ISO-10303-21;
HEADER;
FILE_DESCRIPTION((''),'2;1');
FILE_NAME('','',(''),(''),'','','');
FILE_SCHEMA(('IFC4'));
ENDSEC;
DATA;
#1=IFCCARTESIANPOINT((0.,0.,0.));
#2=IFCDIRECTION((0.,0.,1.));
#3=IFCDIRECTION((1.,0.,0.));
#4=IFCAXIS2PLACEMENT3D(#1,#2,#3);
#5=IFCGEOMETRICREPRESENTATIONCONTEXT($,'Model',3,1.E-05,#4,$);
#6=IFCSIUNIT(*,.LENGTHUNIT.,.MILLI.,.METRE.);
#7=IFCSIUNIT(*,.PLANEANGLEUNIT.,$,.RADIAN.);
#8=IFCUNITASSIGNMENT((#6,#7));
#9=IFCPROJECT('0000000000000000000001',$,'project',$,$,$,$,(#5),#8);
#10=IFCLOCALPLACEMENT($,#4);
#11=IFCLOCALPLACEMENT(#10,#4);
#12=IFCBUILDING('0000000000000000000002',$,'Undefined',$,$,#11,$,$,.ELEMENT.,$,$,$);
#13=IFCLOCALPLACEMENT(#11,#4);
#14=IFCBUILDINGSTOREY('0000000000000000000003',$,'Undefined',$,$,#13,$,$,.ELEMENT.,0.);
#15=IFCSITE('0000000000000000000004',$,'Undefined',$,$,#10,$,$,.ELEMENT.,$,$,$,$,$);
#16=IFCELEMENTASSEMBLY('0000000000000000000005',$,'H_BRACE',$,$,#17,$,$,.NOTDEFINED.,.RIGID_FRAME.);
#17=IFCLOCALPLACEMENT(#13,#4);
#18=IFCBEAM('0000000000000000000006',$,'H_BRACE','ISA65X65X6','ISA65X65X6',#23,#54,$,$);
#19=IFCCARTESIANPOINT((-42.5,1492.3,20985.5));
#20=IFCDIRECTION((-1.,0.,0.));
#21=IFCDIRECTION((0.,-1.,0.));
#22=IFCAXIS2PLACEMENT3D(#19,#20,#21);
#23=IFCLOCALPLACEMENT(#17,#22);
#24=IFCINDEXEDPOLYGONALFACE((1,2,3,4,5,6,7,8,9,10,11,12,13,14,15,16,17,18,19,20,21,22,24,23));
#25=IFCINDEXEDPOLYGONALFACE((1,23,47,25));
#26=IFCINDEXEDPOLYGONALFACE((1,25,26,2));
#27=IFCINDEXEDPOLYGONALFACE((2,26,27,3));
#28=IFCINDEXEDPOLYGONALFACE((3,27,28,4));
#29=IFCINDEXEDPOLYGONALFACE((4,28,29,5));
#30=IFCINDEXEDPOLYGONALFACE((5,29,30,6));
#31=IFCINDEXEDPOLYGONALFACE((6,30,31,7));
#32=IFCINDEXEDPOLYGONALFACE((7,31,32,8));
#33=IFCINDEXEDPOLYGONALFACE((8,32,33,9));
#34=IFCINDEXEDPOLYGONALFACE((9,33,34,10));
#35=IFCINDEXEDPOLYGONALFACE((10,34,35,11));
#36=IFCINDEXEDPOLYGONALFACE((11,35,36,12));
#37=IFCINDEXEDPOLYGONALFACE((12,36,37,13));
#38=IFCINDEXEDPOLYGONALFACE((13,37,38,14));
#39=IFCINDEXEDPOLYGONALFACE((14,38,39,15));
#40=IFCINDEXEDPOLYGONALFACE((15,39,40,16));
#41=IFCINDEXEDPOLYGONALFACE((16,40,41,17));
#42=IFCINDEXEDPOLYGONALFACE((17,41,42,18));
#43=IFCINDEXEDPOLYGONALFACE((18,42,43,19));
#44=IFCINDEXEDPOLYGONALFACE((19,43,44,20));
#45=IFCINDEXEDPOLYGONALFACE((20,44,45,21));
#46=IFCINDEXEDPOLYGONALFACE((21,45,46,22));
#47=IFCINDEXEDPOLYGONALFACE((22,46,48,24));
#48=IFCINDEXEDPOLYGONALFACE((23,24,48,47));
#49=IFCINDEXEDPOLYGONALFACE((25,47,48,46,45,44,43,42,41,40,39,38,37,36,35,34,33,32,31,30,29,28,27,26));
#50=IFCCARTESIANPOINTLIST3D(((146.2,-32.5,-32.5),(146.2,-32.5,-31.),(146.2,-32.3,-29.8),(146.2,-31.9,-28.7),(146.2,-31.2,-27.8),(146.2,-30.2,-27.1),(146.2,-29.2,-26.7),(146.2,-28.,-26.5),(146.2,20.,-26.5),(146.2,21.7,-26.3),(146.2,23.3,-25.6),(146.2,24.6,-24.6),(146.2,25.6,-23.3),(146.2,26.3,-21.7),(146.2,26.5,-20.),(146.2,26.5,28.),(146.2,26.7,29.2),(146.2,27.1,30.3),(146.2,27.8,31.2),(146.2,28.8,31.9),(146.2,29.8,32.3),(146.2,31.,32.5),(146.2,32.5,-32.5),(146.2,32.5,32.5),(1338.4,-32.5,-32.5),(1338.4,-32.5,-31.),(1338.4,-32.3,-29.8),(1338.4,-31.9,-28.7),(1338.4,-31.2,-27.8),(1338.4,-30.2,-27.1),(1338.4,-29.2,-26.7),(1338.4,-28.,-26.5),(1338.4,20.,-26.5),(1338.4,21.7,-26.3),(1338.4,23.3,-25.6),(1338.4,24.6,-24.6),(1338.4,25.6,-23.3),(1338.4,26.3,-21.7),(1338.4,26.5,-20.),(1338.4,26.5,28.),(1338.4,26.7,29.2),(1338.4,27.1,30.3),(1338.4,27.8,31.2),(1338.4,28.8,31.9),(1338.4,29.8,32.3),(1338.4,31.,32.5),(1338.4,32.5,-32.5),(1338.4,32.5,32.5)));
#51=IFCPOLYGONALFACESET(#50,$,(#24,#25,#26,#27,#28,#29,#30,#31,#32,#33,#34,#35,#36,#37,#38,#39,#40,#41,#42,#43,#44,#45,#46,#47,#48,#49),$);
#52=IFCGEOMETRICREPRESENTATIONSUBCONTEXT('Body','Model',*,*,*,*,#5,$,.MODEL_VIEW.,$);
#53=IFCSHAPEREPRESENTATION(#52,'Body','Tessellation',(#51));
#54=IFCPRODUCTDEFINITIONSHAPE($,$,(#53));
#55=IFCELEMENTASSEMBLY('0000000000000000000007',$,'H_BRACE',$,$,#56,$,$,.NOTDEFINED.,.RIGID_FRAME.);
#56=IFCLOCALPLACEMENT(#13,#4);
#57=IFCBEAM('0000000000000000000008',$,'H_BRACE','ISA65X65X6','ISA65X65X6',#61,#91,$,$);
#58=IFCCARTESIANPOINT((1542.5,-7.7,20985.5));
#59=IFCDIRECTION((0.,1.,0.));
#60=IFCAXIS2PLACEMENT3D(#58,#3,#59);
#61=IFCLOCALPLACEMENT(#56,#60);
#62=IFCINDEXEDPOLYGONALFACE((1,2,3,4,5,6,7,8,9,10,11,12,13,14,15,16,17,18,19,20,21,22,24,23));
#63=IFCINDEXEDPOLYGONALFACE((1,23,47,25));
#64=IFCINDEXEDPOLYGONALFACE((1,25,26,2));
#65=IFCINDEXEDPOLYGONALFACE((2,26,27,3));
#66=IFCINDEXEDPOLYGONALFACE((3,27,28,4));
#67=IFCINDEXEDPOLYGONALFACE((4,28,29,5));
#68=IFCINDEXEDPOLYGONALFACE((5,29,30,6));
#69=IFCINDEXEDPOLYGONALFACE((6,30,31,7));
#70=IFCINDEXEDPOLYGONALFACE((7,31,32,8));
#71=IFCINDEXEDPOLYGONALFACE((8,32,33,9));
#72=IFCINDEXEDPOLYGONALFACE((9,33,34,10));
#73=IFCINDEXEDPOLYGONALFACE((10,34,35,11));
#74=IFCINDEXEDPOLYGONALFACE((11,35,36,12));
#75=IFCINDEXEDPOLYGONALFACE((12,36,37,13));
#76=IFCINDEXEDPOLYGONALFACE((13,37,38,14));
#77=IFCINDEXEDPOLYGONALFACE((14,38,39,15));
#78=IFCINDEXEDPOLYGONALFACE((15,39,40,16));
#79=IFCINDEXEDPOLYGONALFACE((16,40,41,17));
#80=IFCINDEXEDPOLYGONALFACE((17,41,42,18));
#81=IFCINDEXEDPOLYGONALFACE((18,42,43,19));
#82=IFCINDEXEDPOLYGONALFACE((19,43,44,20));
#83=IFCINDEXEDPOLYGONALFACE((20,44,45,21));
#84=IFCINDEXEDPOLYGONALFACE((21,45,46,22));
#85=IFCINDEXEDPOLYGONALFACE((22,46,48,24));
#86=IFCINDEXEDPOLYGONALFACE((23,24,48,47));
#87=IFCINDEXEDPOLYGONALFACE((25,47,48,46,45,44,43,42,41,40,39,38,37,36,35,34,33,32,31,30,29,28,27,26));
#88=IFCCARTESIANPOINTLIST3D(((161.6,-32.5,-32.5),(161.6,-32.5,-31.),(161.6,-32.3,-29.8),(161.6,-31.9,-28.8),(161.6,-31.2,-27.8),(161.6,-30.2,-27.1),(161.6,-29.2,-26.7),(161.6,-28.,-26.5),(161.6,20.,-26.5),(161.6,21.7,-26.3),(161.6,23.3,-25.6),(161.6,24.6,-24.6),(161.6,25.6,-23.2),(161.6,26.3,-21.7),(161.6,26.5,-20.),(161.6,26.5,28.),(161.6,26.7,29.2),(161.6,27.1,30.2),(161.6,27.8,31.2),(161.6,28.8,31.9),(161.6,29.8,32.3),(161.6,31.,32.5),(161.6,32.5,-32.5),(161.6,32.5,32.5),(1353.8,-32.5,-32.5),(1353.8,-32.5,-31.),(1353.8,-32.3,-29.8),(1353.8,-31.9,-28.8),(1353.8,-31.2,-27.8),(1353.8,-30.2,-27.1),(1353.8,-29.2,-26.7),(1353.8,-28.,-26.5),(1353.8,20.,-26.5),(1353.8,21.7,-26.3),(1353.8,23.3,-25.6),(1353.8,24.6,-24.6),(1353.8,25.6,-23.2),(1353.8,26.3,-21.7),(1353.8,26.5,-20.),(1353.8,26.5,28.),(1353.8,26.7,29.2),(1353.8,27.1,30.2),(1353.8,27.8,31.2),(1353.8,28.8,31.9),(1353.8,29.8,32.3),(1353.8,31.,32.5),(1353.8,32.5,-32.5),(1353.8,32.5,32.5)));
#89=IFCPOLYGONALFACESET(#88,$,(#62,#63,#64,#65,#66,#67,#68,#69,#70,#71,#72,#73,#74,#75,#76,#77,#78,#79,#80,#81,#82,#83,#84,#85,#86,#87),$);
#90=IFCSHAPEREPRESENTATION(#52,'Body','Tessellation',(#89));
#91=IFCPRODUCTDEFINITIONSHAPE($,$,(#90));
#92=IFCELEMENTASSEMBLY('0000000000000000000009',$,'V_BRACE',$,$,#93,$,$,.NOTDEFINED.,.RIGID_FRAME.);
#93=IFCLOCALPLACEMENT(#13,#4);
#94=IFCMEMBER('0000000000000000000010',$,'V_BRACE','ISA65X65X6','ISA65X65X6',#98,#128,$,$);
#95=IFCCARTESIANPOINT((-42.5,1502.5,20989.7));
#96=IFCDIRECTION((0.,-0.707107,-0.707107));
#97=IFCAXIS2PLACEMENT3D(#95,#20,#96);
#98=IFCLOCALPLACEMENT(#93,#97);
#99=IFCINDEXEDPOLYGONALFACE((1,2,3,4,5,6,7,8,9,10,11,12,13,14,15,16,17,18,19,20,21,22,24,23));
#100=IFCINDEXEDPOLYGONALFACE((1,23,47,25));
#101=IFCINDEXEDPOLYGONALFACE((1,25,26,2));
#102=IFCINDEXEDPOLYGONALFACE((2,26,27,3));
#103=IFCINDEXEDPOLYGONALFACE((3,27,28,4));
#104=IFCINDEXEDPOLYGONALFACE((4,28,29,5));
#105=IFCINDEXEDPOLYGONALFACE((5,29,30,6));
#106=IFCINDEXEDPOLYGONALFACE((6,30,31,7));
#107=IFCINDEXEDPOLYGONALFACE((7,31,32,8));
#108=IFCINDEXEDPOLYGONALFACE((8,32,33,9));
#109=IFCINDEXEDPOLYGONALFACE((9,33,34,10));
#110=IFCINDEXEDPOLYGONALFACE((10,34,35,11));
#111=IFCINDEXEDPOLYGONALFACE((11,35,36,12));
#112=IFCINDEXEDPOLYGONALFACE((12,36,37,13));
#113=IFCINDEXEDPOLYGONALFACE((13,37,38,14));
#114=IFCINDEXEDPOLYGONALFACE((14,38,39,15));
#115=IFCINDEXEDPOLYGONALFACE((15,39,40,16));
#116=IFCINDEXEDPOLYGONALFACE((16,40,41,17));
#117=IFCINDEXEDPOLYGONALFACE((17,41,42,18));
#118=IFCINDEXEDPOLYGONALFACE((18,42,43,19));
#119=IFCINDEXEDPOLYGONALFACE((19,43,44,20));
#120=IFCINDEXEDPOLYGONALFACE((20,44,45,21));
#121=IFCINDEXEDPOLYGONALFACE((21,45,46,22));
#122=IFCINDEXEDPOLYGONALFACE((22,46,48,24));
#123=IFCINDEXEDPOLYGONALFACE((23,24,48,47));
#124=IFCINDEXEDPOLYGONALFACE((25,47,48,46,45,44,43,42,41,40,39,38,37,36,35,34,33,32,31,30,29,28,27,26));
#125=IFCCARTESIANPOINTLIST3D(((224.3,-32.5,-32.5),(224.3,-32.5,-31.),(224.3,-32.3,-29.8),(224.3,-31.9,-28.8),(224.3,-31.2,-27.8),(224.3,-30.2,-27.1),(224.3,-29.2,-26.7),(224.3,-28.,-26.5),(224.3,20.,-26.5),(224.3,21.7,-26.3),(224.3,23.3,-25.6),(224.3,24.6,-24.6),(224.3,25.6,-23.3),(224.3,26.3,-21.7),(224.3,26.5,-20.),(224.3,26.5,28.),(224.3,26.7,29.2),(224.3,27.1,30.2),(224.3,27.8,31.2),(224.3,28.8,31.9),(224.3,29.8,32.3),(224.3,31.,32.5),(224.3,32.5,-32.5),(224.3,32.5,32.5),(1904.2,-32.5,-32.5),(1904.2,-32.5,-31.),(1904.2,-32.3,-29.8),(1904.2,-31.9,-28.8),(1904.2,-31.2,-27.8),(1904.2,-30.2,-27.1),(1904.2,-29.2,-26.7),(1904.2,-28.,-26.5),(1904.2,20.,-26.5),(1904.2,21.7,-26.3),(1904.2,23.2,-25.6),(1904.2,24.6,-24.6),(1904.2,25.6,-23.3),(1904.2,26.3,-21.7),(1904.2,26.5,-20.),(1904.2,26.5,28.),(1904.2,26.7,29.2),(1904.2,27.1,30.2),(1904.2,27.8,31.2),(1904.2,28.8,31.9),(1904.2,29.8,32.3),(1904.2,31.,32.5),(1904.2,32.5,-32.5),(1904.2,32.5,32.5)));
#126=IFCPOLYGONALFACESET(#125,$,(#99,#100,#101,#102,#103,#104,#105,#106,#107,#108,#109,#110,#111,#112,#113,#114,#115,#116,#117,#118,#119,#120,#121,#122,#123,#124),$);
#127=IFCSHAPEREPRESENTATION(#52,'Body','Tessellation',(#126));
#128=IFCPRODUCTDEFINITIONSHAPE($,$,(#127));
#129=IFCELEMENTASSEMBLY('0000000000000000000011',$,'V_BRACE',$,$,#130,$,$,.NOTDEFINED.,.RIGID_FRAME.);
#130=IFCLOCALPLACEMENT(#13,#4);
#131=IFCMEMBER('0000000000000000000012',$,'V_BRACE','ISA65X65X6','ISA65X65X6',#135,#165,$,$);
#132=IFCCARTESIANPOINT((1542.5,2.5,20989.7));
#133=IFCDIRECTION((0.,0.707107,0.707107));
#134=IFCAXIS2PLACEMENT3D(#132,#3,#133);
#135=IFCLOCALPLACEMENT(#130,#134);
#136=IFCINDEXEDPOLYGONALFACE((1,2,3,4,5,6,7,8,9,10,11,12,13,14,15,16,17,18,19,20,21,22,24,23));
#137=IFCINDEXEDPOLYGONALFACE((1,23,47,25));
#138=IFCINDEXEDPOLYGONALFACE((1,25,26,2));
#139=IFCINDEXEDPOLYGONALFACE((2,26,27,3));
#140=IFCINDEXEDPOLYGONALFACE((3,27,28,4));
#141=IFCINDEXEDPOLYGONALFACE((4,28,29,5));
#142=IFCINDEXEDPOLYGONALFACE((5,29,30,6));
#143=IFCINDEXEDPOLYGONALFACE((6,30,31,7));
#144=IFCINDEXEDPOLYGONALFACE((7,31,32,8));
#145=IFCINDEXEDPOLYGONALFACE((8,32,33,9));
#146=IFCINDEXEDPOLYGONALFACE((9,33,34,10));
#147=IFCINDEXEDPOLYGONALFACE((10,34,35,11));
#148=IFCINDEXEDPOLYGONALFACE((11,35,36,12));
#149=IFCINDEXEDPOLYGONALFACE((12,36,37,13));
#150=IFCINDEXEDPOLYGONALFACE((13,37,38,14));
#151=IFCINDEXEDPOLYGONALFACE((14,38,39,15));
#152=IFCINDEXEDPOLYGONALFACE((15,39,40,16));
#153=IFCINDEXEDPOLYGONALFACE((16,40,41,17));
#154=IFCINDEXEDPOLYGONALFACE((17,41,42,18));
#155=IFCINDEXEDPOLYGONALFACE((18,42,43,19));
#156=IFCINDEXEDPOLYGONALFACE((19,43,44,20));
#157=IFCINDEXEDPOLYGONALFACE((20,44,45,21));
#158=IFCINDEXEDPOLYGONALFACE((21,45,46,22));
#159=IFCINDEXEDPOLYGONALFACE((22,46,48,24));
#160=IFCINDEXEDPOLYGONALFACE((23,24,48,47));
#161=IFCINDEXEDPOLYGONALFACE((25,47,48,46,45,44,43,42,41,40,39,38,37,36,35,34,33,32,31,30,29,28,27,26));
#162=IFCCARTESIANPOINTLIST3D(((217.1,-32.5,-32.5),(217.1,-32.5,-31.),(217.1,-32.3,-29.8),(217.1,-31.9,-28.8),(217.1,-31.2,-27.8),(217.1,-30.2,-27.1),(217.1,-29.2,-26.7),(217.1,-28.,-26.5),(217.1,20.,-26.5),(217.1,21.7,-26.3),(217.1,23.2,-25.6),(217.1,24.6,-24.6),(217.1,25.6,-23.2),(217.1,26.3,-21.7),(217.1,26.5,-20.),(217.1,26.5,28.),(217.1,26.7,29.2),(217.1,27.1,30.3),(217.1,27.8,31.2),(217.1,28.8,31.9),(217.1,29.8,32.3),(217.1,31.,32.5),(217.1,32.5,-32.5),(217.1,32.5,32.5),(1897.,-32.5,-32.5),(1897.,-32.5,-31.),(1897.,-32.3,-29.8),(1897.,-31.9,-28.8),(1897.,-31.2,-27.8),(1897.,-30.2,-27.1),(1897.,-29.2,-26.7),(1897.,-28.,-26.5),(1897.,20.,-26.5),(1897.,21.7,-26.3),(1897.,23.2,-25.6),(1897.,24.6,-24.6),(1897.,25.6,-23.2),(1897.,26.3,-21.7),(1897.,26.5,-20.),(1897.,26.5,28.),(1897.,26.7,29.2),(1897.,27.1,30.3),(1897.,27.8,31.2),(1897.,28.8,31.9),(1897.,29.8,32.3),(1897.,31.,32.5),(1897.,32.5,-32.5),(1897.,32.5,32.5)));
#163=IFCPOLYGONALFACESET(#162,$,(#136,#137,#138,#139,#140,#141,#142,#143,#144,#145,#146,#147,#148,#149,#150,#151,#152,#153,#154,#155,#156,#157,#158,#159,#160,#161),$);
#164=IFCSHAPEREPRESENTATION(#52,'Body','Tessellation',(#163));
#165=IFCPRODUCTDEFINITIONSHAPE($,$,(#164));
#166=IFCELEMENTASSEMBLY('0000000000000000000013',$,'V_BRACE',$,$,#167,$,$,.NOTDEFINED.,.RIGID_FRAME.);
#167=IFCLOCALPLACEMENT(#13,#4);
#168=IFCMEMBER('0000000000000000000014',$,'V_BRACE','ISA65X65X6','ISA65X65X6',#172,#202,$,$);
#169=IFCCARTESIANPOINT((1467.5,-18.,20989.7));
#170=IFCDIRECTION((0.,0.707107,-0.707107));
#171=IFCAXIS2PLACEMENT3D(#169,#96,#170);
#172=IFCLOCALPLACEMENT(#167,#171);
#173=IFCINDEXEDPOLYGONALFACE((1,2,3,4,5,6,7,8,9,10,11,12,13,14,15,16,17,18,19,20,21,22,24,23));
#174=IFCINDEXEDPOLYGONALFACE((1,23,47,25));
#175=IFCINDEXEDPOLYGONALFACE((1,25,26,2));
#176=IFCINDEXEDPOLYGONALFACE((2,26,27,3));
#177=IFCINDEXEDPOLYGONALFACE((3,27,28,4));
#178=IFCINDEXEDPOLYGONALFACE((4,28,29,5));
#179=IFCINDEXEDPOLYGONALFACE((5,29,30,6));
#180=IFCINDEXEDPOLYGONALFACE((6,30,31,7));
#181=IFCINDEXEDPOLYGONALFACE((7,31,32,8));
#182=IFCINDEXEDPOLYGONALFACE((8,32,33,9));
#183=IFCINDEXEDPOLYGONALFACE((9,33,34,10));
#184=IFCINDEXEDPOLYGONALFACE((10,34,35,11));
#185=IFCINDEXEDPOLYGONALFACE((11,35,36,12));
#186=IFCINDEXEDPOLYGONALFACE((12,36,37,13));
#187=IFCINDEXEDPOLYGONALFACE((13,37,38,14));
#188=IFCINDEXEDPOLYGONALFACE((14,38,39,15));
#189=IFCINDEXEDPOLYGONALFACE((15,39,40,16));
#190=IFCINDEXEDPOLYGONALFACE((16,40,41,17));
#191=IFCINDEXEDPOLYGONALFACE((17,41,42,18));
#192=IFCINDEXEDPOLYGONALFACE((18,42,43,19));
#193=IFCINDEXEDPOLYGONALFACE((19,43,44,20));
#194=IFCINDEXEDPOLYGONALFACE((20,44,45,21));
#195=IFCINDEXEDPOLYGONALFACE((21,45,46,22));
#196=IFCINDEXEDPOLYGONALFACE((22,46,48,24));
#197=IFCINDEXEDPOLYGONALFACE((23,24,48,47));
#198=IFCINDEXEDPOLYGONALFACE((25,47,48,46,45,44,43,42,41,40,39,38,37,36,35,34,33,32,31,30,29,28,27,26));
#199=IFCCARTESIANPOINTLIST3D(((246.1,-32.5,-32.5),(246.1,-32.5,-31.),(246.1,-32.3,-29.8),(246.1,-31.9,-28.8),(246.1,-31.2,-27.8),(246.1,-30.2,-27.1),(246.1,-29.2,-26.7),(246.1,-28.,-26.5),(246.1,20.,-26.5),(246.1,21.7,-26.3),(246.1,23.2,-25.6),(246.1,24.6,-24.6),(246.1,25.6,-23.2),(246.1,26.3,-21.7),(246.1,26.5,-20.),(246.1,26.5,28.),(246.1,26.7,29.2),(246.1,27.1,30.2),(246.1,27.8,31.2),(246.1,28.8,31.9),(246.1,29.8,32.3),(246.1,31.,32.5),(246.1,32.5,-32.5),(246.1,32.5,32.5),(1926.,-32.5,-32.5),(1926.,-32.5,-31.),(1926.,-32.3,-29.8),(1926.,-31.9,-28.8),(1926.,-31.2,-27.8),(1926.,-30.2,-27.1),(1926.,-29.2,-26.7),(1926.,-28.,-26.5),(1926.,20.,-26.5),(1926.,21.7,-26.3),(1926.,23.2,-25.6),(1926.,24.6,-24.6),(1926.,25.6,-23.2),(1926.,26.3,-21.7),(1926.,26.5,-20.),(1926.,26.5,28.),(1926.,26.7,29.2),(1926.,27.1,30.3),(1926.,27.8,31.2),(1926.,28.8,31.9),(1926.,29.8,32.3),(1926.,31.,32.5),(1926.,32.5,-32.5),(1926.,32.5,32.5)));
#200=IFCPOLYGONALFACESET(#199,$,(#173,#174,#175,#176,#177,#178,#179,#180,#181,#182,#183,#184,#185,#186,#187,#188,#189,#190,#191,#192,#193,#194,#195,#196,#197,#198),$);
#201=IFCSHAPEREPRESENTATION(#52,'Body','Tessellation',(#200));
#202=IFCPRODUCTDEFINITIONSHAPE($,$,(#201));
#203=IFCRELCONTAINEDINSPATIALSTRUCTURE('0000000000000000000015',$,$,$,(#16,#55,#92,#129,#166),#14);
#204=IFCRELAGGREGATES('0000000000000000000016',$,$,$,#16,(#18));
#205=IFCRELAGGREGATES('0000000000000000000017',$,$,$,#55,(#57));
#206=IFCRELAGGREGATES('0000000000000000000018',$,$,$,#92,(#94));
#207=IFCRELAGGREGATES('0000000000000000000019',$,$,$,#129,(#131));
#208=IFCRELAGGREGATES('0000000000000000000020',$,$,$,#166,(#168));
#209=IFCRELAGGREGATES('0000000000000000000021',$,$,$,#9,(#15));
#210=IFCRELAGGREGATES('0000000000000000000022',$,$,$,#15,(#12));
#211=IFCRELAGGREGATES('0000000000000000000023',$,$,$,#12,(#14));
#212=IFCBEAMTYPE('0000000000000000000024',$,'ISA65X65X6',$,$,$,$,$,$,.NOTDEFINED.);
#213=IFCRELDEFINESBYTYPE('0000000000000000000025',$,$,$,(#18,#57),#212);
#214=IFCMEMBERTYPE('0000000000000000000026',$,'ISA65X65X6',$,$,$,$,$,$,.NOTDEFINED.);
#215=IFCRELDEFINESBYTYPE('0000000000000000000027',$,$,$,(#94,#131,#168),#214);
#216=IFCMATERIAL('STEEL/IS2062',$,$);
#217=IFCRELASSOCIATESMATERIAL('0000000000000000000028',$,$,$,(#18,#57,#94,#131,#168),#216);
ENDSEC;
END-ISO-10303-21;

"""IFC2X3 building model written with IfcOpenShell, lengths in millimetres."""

from ifc_helpers import new_model, si_unit, frame, origin_with_axes, origin_2d_with_axis, place, context, subcontext, project, spatial, l_section, extrude, clip, halfspace, material, type_object, element, aggregate, save


model = new_model("IFC2X3")

# Units and contexts
model_context = context("Model", 3, precision=1e-05, world=origin_with_axes())
body_context = subcontext(model_context, "Body", "Model", "MODEL_VIEW")
ifc_project = project(units=[si_unit("LENGTHUNIT", "METRE", prefix="MILLI"), si_unit("PLANEANGLEUNIT", "RADIAN")], contexts=[model_context])

# Site, building, storey
site_placement = place(None, origin_with_axes())
site = spatial("IfcSite", under=ifc_project, at=site_placement, Name="Undefined", CompositionType="ELEMENT")
building_placement = place(site_placement, origin_with_axes())
building = spatial("IfcBuilding", under=site, at=building_placement, Name="Undefined", CompositionType="ELEMENT")
storey_placement = place(building_placement, origin_with_axes())
storey = spatial("IfcBuildingStorey", under=building, at=storey_placement, Name="Undefined", CompositionType="ELEMENT", Elevation=0.0)

# Shared definitions
ifc_material = material(Name="STEEL/IS2062")

# Element assemblies, beams
assembly_1_placement = place(storey_placement, origin_with_axes())
assembly_1 = element("IfcElementAssembly", 1, at=assembly_1_placement, inside=storey, Name="H_BRACE", AssemblyPlace="NOTDEFINED", PredefinedType="RIGID_FRAME")
beam_type_1 = type_object("IfcBeamType", Name="ISA65X65X6", PredefinedType="NOTDEFINED")
beam_1_placement = place(assembly_1_placement, frame((-42.5, 1492.3, 20985.5), z_axis=(-1.0, 0.0, 0.0), x_axis=(0.0, -1.0, 0.0)))
beam_1 = element("IfcBeam", 2, at=beam_1_placement, type_object=beam_type_1, material=ifc_material, Name="H_BRACE", Description="ISA65X65X6", ObjectType="ISA65X65X6", context=body_context, shape_type="Clipping", body=[
    clip(clip(extrude(l_section(Depth=65.0, Width=65.0, Thickness=6.0, FilletRadius=6.5, EdgeRadius=4.5, at=origin_2d_with_axis()), frame((1500.0, 0.0, 0.0), z_axis=(-1.0, 0.0, 0.0), x_axis=(0.0, -1.0, 0.0)), (0.0, 0.0, 1.0), 1500.0), halfspace(frame((1338.4, 0.0, -32.5), z_axis=(-1.0, 0.0, 0.0), x_axis=(0.0, -1.0, 0.0)), True)), halfspace(frame((146.2, 0.0, -32.5), z_axis=(1.0, 0.0, 0.0), x_axis=(0.0, 1.0, 0.0)), True)),
])
aggregate(assembly_1, [beam_1])
assembly_2_placement = place(storey_placement, origin_with_axes())
assembly_2 = element("IfcElementAssembly", 3, at=assembly_2_placement, inside=storey, Name="H_BRACE", AssemblyPlace="NOTDEFINED", PredefinedType="RIGID_FRAME")
beam_2_placement = place(assembly_2_placement, frame((1542.5, -7.7, 20985.5), z_axis=(1.0, 0.0, 0.0), x_axis=(0.0, 1.0, 0.0)))
beam_2 = element("IfcBeam", 4, at=beam_2_placement, type_object=beam_type_1, material=ifc_material, Name="H_BRACE", Description="ISA65X65X6", ObjectType="ISA65X65X6", context=body_context, shape_type="Clipping", body=[
    clip(clip(extrude(l_section(Depth=65.0, Width=65.0, Thickness=6.0, FilletRadius=6.5, EdgeRadius=4.5, at=origin_2d_with_axis()), frame((1500.0, 0.0, 0.0), z_axis=(-1.0, 0.0, 0.0), x_axis=(0.0, -1.0, 0.0)), (0.0, 0.0, 1.0), 1500.0), halfspace(frame((1353.8, 0.0, -42.5), z_axis=(-1.0, 0.0, 0.0), x_axis=(0.0, 1.0, 0.0)), True)), halfspace(frame((161.6, 0.0, -42.5), z_axis=(1.0, 0.0, 0.0), x_axis=(0.0, -1.0, 0.0)), True)),
])
aggregate(assembly_2, [beam_2])

# Element assemblies, members
assembly_3_placement = place(storey_placement, origin_with_axes())
assembly_3 = element("IfcElementAssembly", 5, at=assembly_3_placement, inside=storey, Name="V_BRACE", AssemblyPlace="NOTDEFINED", PredefinedType="RIGID_FRAME")
member_type = type_object("IfcMemberType", Name="ISA65X65X6", PredefinedType="NOTDEFINED")
member_1_placement = place(assembly_3_placement, frame((-42.5, 1502.5, 20989.7), z_axis=(-1.0, 0.0, 0.0), x_axis=(0.0, -0.707107, -0.707107)))
member_1 = element("IfcMember", 6, at=member_1_placement, type_object=member_type, material=ifc_material, Name="V_BRACE", Description="ISA65X65X6", ObjectType="ISA65X65X6", context=body_context, shape_type="Clipping", body=[
    clip(clip(extrude(l_section(Depth=65.0, Width=65.0, Thickness=6.0, FilletRadius=6.5, EdgeRadius=4.5, at=origin_2d_with_axis()), frame((2121.3, 0.0, 0.0), z_axis=(-1.0, 0.0, 0.0), x_axis=(0.0, -1.0, 0.0)), (0.0, 0.0, 1.0), 2121.3), halfspace(frame((1904.2, 0.0, -32.5), z_axis=(-1.0, 0.0, 0.0), x_axis=(0.0, -1.0, 0.0)), True)), halfspace(frame((224.3, 0.0, -32.5), z_axis=(1.0, 0.0, 0.0), x_axis=(0.0, 1.0, 0.0)), True)),
])
aggregate(assembly_3, [member_1])
assembly_4_placement = place(storey_placement, origin_with_axes())
assembly_4 = element("IfcElementAssembly", 7, at=assembly_4_placement, inside=storey, Name="V_BRACE", AssemblyPlace="NOTDEFINED", PredefinedType="RIGID_FRAME")
member_2_placement = place(assembly_4_placement, frame((1542.5, 2.5, 20989.7), z_axis=(1.0, 0.0, 0.0), x_axis=(0.0, 0.707107, 0.707107)))
member_2 = element("IfcMember", 8, at=member_2_placement, type_object=member_type, material=ifc_material, Name="V_BRACE", Description="ISA65X65X6", ObjectType="ISA65X65X6", context=body_context, shape_type="Clipping", body=[
    clip(clip(extrude(l_section(Depth=65.0, Width=65.0, Thickness=6.0, FilletRadius=6.5, EdgeRadius=4.5, at=origin_2d_with_axis()), frame((2121.3, 0.0, 0.0), z_axis=(-1.0, 0.0, 0.0), x_axis=(0.0, -1.0, 0.0)), (0.0, 0.0, 1.0), 2121.3), halfspace(frame((1897.0, 0.0, -42.5), z_axis=(-1.0, 0.0, 0.0), x_axis=(0.0, 1.0, 0.0)), True)), halfspace(frame((217.1, 0.0, -42.5), z_axis=(1.0, 0.0, 0.0), x_axis=(0.0, -1.0, 0.0)), True)),
])
aggregate(assembly_4, [member_2])
assembly_5_placement = place(storey_placement, origin_with_axes())
assembly_5 = element("IfcElementAssembly", 9, at=assembly_5_placement, inside=storey, Name="V_BRACE", AssemblyPlace="NOTDEFINED", PredefinedType="RIGID_FRAME")
member_3_placement = place(assembly_5_placement, frame((1467.5, -18.0, 20989.7), z_axis=(0.0, -0.707107, -0.707107), x_axis=(0.0, 0.707107, -0.707107)))
member_3 = element("IfcMember", 10, at=member_3_placement, type_object=member_type, material=ifc_material, Name="V_BRACE", Description="ISA65X65X6", ObjectType="ISA65X65X6", context=body_context, shape_type="Clipping", body=[
    clip(clip(extrude(l_section(Depth=65.0, Width=65.0, Thickness=6.0, FilletRadius=6.5, EdgeRadius=4.5, at=origin_2d_with_axis()), frame((2121.3, 0.0, 0.0), z_axis=(-1.0, 0.0, 0.0), x_axis=(0.0, -1.0, 0.0)), (0.0, 0.0, 1.0), 2121.3), halfspace(frame((1926.0, 32.5, 0.0), z_axis=(-1.0, 0.0, 0.0), x_axis=(0.0, 0.0, -1.0)), True)), halfspace(frame((246.1, 32.5, 0.0), z_axis=(1.0, 0.0, 0.0), x_axis=(0.0, 0.0, 1.0)), True)),
])
aggregate(assembly_5, [member_3])

save(model, "model.ifc")
